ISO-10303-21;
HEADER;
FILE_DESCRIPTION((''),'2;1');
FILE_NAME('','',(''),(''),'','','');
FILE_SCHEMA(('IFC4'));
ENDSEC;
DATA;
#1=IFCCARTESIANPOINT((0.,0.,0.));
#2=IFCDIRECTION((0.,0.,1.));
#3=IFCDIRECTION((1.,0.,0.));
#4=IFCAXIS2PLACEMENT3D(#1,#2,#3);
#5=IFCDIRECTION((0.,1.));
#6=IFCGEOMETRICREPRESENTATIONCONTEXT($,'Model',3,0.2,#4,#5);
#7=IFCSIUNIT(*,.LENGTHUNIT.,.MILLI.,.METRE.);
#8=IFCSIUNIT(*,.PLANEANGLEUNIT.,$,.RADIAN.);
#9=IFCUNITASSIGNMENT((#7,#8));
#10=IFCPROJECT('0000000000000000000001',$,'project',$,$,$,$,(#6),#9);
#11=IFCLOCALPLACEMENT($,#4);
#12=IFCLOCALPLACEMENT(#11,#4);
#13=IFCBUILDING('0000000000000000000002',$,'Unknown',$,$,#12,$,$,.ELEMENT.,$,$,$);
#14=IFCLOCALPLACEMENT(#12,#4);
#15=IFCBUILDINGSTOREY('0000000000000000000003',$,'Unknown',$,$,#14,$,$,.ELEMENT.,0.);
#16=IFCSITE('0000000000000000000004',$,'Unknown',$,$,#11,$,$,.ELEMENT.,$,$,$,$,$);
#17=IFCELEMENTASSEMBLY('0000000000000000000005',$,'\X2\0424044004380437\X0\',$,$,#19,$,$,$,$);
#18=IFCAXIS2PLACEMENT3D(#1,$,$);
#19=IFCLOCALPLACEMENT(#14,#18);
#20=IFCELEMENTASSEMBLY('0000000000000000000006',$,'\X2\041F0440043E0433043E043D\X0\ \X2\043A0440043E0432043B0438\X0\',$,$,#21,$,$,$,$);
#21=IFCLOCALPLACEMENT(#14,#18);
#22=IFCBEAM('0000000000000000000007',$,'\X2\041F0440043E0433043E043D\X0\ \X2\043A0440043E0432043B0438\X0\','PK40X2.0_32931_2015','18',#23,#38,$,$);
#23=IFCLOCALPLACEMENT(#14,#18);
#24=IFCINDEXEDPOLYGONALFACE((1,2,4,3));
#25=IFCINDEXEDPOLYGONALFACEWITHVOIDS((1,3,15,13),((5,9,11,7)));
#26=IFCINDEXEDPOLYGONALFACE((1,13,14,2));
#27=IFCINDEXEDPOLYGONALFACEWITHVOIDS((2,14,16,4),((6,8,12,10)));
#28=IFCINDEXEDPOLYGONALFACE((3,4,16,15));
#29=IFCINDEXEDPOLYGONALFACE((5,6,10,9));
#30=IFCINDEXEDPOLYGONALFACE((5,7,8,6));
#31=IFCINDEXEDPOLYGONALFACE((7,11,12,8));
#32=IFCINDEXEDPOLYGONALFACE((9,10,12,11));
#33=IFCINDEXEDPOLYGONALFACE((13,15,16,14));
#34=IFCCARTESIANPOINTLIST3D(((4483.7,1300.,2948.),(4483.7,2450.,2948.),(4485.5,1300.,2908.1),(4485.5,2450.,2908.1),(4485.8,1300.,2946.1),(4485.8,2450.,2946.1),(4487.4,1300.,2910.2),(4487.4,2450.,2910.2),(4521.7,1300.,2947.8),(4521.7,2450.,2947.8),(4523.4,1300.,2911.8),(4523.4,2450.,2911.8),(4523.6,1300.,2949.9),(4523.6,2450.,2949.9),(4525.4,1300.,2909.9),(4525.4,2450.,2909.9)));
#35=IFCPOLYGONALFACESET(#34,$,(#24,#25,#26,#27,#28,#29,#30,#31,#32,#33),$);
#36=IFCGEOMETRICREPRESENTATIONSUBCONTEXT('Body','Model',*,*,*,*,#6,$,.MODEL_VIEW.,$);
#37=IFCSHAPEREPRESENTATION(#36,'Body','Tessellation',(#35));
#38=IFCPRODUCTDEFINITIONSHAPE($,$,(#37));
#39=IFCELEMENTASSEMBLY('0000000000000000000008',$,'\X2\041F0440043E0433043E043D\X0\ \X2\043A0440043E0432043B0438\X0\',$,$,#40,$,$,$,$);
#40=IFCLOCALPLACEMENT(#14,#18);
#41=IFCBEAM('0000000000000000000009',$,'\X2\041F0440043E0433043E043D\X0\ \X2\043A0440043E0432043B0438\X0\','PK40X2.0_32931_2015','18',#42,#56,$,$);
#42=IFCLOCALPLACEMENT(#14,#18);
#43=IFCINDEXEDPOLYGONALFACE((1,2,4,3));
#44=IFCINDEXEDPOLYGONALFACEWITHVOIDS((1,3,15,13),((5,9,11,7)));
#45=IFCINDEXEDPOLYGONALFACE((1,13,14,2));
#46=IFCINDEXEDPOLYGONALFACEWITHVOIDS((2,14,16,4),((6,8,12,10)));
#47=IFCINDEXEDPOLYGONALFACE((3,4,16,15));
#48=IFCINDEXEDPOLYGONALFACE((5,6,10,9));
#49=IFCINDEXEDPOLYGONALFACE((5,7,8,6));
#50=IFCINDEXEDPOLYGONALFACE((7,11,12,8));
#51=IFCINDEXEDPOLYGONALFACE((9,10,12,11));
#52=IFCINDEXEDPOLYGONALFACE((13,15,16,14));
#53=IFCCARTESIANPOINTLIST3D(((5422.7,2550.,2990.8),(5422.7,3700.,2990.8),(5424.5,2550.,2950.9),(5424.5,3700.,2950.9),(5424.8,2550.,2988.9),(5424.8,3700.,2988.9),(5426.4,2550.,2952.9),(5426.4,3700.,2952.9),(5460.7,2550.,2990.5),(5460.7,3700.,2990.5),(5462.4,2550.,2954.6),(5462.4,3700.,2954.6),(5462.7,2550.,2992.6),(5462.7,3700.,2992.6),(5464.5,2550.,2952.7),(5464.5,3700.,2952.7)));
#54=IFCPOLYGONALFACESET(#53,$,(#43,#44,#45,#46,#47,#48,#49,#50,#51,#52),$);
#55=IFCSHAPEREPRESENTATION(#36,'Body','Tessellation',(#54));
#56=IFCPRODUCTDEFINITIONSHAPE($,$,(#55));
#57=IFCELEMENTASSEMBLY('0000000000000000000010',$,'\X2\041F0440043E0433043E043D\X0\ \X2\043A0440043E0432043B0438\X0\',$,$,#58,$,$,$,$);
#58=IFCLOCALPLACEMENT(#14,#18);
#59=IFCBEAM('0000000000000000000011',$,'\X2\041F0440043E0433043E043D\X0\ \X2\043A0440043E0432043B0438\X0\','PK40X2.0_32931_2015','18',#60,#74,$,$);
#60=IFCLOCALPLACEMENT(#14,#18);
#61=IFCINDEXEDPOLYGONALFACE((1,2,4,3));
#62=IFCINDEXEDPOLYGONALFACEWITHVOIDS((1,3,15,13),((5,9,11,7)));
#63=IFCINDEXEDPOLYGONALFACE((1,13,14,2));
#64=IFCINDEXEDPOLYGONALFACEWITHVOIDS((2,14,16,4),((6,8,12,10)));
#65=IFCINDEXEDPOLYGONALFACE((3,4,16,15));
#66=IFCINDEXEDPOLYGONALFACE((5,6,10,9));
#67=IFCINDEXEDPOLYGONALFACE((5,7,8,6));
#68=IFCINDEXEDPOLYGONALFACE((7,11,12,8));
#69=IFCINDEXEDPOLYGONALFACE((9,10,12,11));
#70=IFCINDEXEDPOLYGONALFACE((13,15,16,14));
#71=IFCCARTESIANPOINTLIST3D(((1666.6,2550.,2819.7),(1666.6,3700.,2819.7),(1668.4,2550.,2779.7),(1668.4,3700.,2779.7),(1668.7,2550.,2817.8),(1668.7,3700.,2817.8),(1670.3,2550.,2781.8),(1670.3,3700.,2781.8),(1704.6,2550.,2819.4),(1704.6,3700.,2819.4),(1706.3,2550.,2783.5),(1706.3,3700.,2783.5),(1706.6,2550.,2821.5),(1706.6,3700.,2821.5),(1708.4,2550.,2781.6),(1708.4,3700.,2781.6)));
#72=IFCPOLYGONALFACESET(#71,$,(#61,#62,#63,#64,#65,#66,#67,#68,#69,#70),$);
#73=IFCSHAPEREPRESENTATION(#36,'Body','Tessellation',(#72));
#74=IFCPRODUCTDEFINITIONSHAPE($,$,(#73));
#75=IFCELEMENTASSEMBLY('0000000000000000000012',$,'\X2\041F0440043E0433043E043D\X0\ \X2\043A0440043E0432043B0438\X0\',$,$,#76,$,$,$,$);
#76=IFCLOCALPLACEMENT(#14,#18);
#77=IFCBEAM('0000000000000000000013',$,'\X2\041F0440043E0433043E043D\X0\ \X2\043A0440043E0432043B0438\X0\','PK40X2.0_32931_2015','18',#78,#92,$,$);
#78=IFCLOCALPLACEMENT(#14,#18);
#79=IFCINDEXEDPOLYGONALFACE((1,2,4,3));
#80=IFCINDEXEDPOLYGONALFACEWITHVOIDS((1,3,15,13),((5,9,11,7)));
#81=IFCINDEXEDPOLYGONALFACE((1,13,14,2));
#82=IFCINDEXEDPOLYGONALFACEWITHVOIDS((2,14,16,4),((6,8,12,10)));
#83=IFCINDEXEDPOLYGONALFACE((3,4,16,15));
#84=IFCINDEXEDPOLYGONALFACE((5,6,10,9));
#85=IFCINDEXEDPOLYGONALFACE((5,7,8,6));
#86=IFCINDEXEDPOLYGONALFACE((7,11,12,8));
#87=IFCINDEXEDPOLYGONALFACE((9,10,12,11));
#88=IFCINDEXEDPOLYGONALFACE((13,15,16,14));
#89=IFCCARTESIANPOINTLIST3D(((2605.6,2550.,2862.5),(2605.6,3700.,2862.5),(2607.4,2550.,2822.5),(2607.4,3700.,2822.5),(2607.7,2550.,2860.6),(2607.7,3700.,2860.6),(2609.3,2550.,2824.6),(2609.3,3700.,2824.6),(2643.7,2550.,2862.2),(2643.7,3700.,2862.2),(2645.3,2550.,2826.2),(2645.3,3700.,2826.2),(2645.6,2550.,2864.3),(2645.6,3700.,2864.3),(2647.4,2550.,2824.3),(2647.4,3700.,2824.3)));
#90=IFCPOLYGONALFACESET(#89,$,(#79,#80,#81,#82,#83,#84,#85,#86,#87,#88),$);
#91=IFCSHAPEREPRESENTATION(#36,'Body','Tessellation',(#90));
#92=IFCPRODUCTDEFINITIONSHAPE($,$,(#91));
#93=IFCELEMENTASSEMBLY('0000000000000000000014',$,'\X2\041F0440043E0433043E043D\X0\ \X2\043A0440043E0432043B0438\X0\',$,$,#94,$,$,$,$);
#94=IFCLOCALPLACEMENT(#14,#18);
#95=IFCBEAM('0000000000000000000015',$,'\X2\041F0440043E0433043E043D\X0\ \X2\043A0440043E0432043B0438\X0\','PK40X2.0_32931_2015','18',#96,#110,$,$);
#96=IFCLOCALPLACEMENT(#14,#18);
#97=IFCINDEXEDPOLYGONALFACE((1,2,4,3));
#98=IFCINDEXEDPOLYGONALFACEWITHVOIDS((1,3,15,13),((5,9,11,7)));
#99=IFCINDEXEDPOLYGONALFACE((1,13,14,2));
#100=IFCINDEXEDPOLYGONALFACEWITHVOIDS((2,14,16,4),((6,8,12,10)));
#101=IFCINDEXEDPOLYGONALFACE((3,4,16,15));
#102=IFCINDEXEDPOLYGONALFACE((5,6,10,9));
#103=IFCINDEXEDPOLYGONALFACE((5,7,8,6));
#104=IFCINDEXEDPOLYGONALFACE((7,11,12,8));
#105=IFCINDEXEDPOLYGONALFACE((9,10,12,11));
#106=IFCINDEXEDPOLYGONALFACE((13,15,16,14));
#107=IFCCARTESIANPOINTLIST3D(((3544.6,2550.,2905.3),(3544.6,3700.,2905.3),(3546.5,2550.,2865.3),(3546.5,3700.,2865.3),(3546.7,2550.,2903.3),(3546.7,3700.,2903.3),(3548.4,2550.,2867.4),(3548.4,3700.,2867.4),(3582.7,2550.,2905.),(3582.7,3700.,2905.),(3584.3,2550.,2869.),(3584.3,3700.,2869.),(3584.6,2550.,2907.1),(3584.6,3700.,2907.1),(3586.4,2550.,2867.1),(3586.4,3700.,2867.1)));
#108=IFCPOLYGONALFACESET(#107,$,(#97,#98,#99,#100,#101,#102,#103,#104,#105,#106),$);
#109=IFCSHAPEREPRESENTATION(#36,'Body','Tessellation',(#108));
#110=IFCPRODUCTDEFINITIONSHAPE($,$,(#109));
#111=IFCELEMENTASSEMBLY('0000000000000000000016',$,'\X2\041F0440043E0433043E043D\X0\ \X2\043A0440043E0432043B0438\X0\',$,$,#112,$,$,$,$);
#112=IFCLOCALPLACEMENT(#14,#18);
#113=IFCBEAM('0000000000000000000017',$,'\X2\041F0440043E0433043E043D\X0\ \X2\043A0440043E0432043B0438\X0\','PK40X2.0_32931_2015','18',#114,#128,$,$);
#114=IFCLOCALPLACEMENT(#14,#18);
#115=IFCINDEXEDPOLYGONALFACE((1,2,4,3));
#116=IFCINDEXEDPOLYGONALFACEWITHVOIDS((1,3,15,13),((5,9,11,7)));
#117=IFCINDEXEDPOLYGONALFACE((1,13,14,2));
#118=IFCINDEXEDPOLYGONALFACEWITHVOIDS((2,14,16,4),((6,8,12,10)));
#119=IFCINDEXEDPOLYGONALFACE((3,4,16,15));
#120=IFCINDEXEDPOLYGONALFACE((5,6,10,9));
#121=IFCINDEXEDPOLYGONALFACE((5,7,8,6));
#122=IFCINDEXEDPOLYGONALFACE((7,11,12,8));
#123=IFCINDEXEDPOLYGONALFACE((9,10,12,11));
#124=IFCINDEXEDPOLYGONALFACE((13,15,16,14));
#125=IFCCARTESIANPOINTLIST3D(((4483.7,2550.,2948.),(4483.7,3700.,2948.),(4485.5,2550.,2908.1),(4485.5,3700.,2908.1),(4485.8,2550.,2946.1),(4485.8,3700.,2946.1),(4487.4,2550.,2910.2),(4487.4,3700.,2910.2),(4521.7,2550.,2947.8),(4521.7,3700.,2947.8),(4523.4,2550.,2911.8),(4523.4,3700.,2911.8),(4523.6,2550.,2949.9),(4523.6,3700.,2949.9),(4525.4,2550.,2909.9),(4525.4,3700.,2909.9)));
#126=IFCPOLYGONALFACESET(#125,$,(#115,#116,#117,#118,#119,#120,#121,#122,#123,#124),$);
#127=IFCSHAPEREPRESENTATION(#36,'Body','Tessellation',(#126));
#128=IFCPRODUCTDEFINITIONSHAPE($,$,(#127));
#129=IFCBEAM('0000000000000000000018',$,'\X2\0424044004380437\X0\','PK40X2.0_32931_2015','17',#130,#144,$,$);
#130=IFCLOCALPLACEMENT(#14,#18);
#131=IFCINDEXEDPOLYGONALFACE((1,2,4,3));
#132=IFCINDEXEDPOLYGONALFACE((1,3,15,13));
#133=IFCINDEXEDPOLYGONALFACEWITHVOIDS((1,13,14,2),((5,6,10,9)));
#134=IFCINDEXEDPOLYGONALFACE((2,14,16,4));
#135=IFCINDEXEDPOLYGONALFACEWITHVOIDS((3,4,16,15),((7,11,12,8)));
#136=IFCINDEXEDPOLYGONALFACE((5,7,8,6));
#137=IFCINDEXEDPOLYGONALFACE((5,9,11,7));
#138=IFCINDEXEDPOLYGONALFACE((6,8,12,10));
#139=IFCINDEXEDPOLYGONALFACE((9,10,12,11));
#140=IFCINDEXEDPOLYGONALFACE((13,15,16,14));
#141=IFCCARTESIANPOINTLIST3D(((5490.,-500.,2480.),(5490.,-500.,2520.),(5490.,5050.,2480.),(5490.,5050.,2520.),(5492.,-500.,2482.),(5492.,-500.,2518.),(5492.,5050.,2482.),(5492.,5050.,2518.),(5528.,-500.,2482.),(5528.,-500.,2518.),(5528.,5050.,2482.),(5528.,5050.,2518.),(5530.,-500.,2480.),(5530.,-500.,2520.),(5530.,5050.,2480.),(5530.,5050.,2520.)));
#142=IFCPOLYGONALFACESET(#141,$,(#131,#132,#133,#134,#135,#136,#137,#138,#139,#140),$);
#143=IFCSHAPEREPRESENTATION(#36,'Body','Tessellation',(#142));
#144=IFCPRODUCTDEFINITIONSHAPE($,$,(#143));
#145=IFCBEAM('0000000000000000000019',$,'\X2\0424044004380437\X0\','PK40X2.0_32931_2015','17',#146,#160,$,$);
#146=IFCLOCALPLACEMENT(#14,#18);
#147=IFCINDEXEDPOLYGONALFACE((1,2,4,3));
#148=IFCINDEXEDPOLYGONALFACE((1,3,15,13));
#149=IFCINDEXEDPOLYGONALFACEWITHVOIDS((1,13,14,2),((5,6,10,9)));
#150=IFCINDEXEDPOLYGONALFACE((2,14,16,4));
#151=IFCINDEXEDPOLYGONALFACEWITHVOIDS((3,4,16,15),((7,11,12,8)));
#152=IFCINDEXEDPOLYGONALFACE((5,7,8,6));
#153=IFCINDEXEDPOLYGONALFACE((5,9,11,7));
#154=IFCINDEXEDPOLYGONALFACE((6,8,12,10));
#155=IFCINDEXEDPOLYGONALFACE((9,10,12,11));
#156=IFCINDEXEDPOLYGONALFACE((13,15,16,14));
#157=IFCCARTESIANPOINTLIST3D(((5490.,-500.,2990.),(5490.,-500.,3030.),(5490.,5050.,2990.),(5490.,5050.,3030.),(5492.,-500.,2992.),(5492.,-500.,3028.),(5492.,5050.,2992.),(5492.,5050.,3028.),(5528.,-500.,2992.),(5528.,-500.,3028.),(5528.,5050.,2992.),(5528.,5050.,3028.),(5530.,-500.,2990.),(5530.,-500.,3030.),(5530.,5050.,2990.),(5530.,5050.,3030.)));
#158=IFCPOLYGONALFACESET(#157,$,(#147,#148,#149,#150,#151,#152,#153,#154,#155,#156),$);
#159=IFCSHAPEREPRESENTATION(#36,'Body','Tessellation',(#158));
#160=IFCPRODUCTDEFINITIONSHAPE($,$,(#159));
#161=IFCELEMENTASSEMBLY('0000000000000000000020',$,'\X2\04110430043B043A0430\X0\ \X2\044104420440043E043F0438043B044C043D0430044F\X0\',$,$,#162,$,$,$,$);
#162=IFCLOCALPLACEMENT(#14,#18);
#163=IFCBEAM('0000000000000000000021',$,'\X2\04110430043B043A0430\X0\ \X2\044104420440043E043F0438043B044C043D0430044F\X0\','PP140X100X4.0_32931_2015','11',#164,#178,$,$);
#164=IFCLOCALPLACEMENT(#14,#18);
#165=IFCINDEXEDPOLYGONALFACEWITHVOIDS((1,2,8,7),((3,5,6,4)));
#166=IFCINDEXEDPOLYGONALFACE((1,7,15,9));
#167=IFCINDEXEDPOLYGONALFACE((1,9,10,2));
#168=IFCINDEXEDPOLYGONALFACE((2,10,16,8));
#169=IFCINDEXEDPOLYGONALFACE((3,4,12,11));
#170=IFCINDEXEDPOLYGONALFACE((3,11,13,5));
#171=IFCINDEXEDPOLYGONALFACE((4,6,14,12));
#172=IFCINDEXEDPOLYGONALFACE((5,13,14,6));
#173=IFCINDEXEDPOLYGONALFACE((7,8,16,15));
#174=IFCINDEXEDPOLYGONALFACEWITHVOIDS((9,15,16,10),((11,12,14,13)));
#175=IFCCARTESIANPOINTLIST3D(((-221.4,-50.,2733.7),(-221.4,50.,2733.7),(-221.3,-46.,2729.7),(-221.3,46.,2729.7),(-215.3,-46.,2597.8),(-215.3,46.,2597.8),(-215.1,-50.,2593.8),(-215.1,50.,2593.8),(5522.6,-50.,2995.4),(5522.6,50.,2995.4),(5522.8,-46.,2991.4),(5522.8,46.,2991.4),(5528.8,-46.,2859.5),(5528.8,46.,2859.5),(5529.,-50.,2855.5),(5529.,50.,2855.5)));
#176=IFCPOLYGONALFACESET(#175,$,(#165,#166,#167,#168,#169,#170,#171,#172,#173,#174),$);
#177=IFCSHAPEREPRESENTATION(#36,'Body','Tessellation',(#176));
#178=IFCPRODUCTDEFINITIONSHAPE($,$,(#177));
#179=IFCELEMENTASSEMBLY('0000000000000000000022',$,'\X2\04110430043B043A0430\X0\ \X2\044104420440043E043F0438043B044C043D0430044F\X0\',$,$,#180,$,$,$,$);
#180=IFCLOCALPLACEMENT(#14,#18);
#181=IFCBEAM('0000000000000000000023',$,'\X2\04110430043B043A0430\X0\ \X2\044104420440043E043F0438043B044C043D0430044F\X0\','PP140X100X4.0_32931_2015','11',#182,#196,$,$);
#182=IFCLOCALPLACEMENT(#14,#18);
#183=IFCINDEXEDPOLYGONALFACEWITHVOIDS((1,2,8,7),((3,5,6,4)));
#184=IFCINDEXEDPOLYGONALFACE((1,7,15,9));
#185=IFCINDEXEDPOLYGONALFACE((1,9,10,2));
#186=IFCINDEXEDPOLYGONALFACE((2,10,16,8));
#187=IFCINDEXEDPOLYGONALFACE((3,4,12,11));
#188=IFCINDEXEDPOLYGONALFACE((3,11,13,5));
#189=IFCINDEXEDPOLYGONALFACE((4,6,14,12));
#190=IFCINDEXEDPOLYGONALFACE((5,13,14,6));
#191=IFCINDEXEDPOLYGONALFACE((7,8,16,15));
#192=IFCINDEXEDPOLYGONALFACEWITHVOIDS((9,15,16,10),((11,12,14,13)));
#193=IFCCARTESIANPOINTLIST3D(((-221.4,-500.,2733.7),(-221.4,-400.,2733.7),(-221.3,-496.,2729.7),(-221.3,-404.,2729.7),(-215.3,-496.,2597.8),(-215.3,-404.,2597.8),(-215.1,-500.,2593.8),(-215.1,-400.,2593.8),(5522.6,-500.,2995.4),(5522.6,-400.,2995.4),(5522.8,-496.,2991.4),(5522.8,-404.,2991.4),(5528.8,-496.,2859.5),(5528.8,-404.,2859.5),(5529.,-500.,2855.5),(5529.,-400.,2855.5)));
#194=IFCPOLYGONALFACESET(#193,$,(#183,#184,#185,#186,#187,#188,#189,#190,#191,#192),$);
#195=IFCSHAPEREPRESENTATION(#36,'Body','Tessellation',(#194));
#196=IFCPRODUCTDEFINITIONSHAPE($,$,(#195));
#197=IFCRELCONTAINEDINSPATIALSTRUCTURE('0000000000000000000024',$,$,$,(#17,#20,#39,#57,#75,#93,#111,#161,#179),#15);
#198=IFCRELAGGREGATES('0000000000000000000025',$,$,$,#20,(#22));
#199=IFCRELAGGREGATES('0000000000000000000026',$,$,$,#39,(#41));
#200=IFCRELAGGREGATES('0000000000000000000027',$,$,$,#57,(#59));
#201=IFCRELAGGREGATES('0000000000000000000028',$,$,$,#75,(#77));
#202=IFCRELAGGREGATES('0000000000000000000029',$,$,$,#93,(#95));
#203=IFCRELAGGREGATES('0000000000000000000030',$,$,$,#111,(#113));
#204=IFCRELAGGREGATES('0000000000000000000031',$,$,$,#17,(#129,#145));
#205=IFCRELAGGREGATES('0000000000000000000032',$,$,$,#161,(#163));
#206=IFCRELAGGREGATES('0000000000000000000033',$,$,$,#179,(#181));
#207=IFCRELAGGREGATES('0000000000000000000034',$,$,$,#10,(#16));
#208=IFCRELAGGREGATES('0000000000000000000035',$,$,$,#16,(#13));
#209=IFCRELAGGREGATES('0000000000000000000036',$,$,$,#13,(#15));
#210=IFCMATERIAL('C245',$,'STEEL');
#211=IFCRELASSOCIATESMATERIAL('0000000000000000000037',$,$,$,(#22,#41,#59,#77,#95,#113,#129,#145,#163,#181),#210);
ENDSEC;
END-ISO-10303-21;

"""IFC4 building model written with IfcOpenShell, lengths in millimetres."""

from ifc_helpers import new_model, si_unit, direction, frame, origin_with_axes, place, context, subcontext, project, spatial, line, indexed_curve, outline, extrude, material, element, aggregate, save


model = new_model("IFC4")

# Units and contexts
model_context = context("Model", 3, precision=0.2, world=origin_with_axes(), true_north=direction((0.0, 1.0)))
body_context = subcontext(model_context, "Body", "Model", "MODEL_VIEW")
ifc_project = project(units=[si_unit("LENGTHUNIT", "METRE", prefix="MILLI"), si_unit("PLANEANGLEUNIT", "RADIAN")], contexts=[model_context])

# Site, building, storey
site_placement = place(None, origin_with_axes())
site = spatial("IfcSite", under=ifc_project, at=site_placement, Name="Unknown", CompositionType="ELEMENT")
building_placement = place(site_placement, origin_with_axes())
building = spatial("IfcBuilding", under=site, at=building_placement, Name="Unknown", CompositionType="ELEMENT")
storey_placement = place(building_placement, origin_with_axes())
storey = spatial("IfcBuildingStorey", under=building, at=storey_placement, Name="Unknown", CompositionType="ELEMENT", Elevation=0.0)

# Element assembly
assembly_1_placement = place(storey_placement, frame((5510.0, -500.0, 3010.0), z_axis=(1.0, 0.0, 0.0), x_axis=(0.0, 1.0, 0.0)))
assembly_1 = element("IfcElementAssembly", 1, at=assembly_1_placement, inside=storey, Name="Фриз")
ifc_material = material(Name="C245", Category="STEEL")

# Element assemblies, beams
assembly_2_placement = place(storey_placement, frame((4504.6, 2450.0, 2929.0), z_axis=(-0.998964, 0.0, -0.045508), x_axis=(0.0, -1.0, 0.0)))
assembly_2 = element("IfcElementAssembly", 2, at=assembly_2_placement, inside=storey, Name="Прогон кровли")
beam_1_placement = place(assembly_2_placement, origin_with_axes())
beam_1 = element("IfcBeam", 3, at=beam_1_placement, material=ifc_material, Name="Прогон кровли", Description="PK40X2.0_32931_2015", ObjectType="18", context=body_context, shape_type="SolidModel", body=[
    extrude(outline(indexed_curve([(-20.0, -20.0), (20.0, -20.0), (20.0, 20.0), (-20.0, 20.0)], segments=[line(1, 2, 3, 4, 1)]), holes=[indexed_curve([(-18.0, -18.0), (-18.0, 18.0), (18.0, 18.0), (18.0, -18.0)], segments=[line(1, 2, 3, 4, 1)])]), frame((0.0, 0.0, 0.0), z_axis=(-1.0, 0.0, 0.0), x_axis=(0.0, 0.0, 1.0)), (0.0, 0.0, -1.0), 1150.0),
])
aggregate(assembly_2, [beam_1])
assembly_3_placement = place(storey_placement, frame((5443.6, 3700.0, 2971.7), z_axis=(-0.998964, 0.0, -0.045508), x_axis=(0.0, -1.0, 0.0)))
assembly_3 = element("IfcElementAssembly", 4, at=assembly_3_placement, inside=storey, Name="Прогон кровли")
beam_2_placement = place(assembly_3_placement, origin_with_axes())
beam_2 = element("IfcBeam", 5, at=beam_2_placement, material=ifc_material, Name="Прогон кровли", Description="PK40X2.0_32931_2015", ObjectType="18", context=body_context, shape_type="SolidModel", body=[
    extrude(outline(indexed_curve([(-20.0, -20.0), (20.0, -20.0), (20.0, 20.0), (-20.0, 20.0)], segments=[line(1, 2, 3, 4, 1)]), holes=[indexed_curve([(-18.0, -18.0), (-18.0, 18.0), (18.0, 18.0), (18.0, -18.0)], segments=[line(1, 2, 3, 4, 1)])]), frame((0.0, 0.0, 0.0), z_axis=(-1.0, 0.0, 0.0), x_axis=(0.0, 0.0, 1.0)), (0.0, 0.0, -1.0), 1150.0),
])
aggregate(assembly_3, [beam_2])
assembly_4_placement = place(storey_placement, frame((1687.5, 3700.0, 2800.6), z_axis=(-0.998964, 0.0, -0.045508), x_axis=(0.0, -1.0, 0.0)))
assembly_4 = element("IfcElementAssembly", 6, at=assembly_4_placement, inside=storey, Name="Прогон кровли")
beam_3_placement = place(assembly_4_placement, origin_with_axes())
beam_3 = element("IfcBeam", 7, at=beam_3_placement, material=ifc_material, Name="Прогон кровли", Description="PK40X2.0_32931_2015", ObjectType="18", context=body_context, shape_type="SolidModel", body=[
    extrude(outline(indexed_curve([(-20.0, -20.0), (20.0, -20.0), (20.0, 20.0), (-20.0, 20.0)], segments=[line(1, 2, 3, 4, 1)]), holes=[indexed_curve([(-18.0, -18.0), (-18.0, 18.0), (18.0, 18.0), (18.0, -18.0)], segments=[line(1, 2, 3, 4, 1)])]), frame((0.0, 0.0, 0.0), z_axis=(-1.0, 0.0, 0.0), x_axis=(0.0, 0.0, 1.0)), (0.0, 0.0, -1.0), 1150.0),
])
aggregate(assembly_4, [beam_3])
assembly_5_placement = place(storey_placement, frame((2626.5, 3700.0, 2843.4), z_axis=(-0.998964, 0.0, -0.045508), x_axis=(0.0, -1.0, 0.0)))
assembly_5 = element("IfcElementAssembly", 8, at=assembly_5_placement, inside=storey, Name="Прогон кровли")
beam_4_placement = place(assembly_5_placement, origin_with_axes())
beam_4 = element("IfcBeam", 9, at=beam_4_placement, material=ifc_material, Name="Прогон кровли", Description="PK40X2.0_32931_2015", ObjectType="18", context=body_context, shape_type="SolidModel", body=[
    extrude(outline(indexed_curve([(-20.0, -20.0), (20.0, -20.0), (20.0, 20.0), (-20.0, 20.0)], segments=[line(1, 2, 3, 4, 1)]), holes=[indexed_curve([(-18.0, -18.0), (-18.0, 18.0), (18.0, 18.0), (18.0, -18.0)], segments=[line(1, 2, 3, 4, 1)])]), frame((0.0, 0.0, 0.0), z_axis=(-1.0, 0.0, 0.0), x_axis=(0.0, 0.0, 1.0)), (0.0, 0.0, -1.0), 1150.0),
])
aggregate(assembly_5, [beam_4])
assembly_6_placement = place(storey_placement, frame((3565.5, 3700.0, 2886.2), z_axis=(-0.998964, 0.0, -0.045508), x_axis=(0.0, -1.0, 0.0)))
assembly_6 = element("IfcElementAssembly", 10, at=assembly_6_placement, inside=storey, Name="Прогон кровли")
beam_5_placement = place(assembly_6_placement, origin_with_axes())
beam_5 = element("IfcBeam", 11, at=beam_5_placement, material=ifc_material, Name="Прогон кровли", Description="PK40X2.0_32931_2015", ObjectType="18", context=body_context, shape_type="SolidModel", body=[
    extrude(outline(indexed_curve([(-20.0, -20.0), (20.0, -20.0), (20.0, 20.0), (-20.0, 20.0)], segments=[line(1, 2, 3, 4, 1)]), holes=[indexed_curve([(-18.0, -18.0), (-18.0, 18.0), (18.0, 18.0), (18.0, -18.0)], segments=[line(1, 2, 3, 4, 1)])]), frame((0.0, 0.0, 0.0), z_axis=(-1.0, 0.0, 0.0), x_axis=(0.0, 0.0, 1.0)), (0.0, 0.0, -1.0), 1150.0),
])
aggregate(assembly_6, [beam_5])
assembly_7_placement = place(storey_placement, frame((4504.6, 3700.0, 2929.0), z_axis=(-0.998964, 0.0, -0.045508), x_axis=(0.0, -1.0, 0.0)))
assembly_7 = element("IfcElementAssembly", 12, at=assembly_7_placement, inside=storey, Name="Прогон кровли")
beam_6_placement = place(assembly_7_placement, origin_with_axes())
beam_6 = element("IfcBeam", 13, at=beam_6_placement, material=ifc_material, Name="Прогон кровли", Description="PK40X2.0_32931_2015", ObjectType="18", context=body_context, shape_type="SolidModel", body=[
    extrude(outline(indexed_curve([(-20.0, -20.0), (20.0, -20.0), (20.0, 20.0), (-20.0, 20.0)], segments=[line(1, 2, 3, 4, 1)]), holes=[indexed_curve([(-18.0, -18.0), (-18.0, 18.0), (18.0, 18.0), (18.0, -18.0)], segments=[line(1, 2, 3, 4, 1)])]), frame((0.0, 0.0, 0.0), z_axis=(-1.0, 0.0, 0.0), x_axis=(0.0, 0.0, 1.0)), (0.0, 0.0, -1.0), 1150.0),
])
aggregate(assembly_7, [beam_6])

# Beams
beam_7_placement = place(assembly_1_placement, frame((0.0, -510.0, 0.0), z_axis=(0.0, 0.0, 1.0), x_axis=(1.0, 0.0, 0.0)))
beam_7 = element("IfcBeam", 14, at=beam_7_placement, material=ifc_material, Name="Фриз", Description="PK40X2.0_32931_2015", ObjectType="17", context=body_context, shape_type="SolidModel", body=[
    extrude(outline(indexed_curve([(-20.0, -20.0), (20.0, -20.0), (20.0, 20.0), (-20.0, 20.0)], segments=[line(1, 2, 3, 4, 1)]), holes=[indexed_curve([(-18.0, -18.0), (-18.0, 18.0), (18.0, 18.0), (18.0, -18.0)], segments=[line(1, 2, 3, 4, 1)])]), frame((0.0, 0.0, 0.0), z_axis=(-1.0, 0.0, 0.0), x_axis=(0.0, 0.0, 1.0)), (0.0, 0.0, -1.0), 5550.0),
])
beam_8_placement = place(assembly_1_placement, origin_with_axes())
beam_8 = element("IfcBeam", 15, at=beam_8_placement, material=ifc_material, Name="Фриз", Description="PK40X2.0_32931_2015", ObjectType="17", context=body_context, shape_type="SolidModel", body=[
    extrude(outline(indexed_curve([(-20.0, -20.0), (20.0, -20.0), (20.0, 20.0), (-20.0, 20.0)], segments=[line(1, 2, 3, 4, 1)]), holes=[indexed_curve([(-18.0, -18.0), (-18.0, 18.0), (18.0, 18.0), (18.0, -18.0)], segments=[line(1, 2, 3, 4, 1)])]), frame((0.0, 0.0, 0.0), z_axis=(-1.0, 0.0, 0.0), x_axis=(0.0, 0.0, 1.0)), (0.0, 0.0, -1.0), 5550.0),
])
aggregate(assembly_1, [beam_7, beam_8])

# Element assemblies, beams
assembly_8_placement = place(storey_placement, frame((5525.8, 0.0, 2925.4), z_axis=(0.0, 1.0, 0.0), x_axis=(-0.998964, 0.0, -0.045508)))
assembly_8 = element("IfcElementAssembly", 16, at=assembly_8_placement, inside=storey, Name="Балка стропильная")
beam_9_placement = place(assembly_8_placement, origin_with_axes())
beam_9 = element("IfcBeam", 17, at=beam_9_placement, material=ifc_material, Name="Балка стропильная", Description="PP140X100X4.0_32931_2015", ObjectType="11", context=body_context, shape_type="SolidModel", body=[
    extrude(outline(indexed_curve([(-50.0, -70.0), (50.0, -70.0), (50.0, 70.0), (-50.0, 70.0)], segments=[line(1, 2, 3, 4, 1)]), holes=[indexed_curve([(-46.0, -66.0), (-46.0, 66.0), (46.0, 66.0), (46.0, -66.0)], segments=[line(1, 2, 3, 4, 1)])]), frame((0.0, 0.0, 0.0), z_axis=(-1.0, 0.0, 0.0), x_axis=(0.0, 0.0, 1.0)), (0.0, 0.0, -1.0), 5750.0),
])
aggregate(assembly_8, [beam_9])
assembly_9_placement = place(storey_placement, frame((5525.8, -450.0, 2925.4), z_axis=(0.0, 1.0, 0.0), x_axis=(-0.998964, 0.0, -0.045508)))
assembly_9 = element("IfcElementAssembly", 18, at=assembly_9_placement, inside=storey, Name="Балка стропильная")
beam_10_placement = place(assembly_9_placement, origin_with_axes())
beam_10 = element("IfcBeam", 19, at=beam_10_placement, material=ifc_material, Name="Балка стропильная", Description="PP140X100X4.0_32931_2015", ObjectType="11", context=body_context, shape_type="SolidModel", body=[
    extrude(outline(indexed_curve([(-50.0, -70.0), (50.0, -70.0), (50.0, 70.0), (-50.0, 70.0)], segments=[line(1, 2, 3, 4, 1)]), holes=[indexed_curve([(-46.0, -66.0), (-46.0, 66.0), (46.0, 66.0), (46.0, -66.0)], segments=[line(1, 2, 3, 4, 1)])]), frame((0.0, 0.0, 0.0), z_axis=(-1.0, 0.0, 0.0), x_axis=(0.0, 0.0, 1.0)), (0.0, 0.0, -1.0), 5750.0),
])
aggregate(assembly_9, [beam_10])

save(model, "model.ifc")
